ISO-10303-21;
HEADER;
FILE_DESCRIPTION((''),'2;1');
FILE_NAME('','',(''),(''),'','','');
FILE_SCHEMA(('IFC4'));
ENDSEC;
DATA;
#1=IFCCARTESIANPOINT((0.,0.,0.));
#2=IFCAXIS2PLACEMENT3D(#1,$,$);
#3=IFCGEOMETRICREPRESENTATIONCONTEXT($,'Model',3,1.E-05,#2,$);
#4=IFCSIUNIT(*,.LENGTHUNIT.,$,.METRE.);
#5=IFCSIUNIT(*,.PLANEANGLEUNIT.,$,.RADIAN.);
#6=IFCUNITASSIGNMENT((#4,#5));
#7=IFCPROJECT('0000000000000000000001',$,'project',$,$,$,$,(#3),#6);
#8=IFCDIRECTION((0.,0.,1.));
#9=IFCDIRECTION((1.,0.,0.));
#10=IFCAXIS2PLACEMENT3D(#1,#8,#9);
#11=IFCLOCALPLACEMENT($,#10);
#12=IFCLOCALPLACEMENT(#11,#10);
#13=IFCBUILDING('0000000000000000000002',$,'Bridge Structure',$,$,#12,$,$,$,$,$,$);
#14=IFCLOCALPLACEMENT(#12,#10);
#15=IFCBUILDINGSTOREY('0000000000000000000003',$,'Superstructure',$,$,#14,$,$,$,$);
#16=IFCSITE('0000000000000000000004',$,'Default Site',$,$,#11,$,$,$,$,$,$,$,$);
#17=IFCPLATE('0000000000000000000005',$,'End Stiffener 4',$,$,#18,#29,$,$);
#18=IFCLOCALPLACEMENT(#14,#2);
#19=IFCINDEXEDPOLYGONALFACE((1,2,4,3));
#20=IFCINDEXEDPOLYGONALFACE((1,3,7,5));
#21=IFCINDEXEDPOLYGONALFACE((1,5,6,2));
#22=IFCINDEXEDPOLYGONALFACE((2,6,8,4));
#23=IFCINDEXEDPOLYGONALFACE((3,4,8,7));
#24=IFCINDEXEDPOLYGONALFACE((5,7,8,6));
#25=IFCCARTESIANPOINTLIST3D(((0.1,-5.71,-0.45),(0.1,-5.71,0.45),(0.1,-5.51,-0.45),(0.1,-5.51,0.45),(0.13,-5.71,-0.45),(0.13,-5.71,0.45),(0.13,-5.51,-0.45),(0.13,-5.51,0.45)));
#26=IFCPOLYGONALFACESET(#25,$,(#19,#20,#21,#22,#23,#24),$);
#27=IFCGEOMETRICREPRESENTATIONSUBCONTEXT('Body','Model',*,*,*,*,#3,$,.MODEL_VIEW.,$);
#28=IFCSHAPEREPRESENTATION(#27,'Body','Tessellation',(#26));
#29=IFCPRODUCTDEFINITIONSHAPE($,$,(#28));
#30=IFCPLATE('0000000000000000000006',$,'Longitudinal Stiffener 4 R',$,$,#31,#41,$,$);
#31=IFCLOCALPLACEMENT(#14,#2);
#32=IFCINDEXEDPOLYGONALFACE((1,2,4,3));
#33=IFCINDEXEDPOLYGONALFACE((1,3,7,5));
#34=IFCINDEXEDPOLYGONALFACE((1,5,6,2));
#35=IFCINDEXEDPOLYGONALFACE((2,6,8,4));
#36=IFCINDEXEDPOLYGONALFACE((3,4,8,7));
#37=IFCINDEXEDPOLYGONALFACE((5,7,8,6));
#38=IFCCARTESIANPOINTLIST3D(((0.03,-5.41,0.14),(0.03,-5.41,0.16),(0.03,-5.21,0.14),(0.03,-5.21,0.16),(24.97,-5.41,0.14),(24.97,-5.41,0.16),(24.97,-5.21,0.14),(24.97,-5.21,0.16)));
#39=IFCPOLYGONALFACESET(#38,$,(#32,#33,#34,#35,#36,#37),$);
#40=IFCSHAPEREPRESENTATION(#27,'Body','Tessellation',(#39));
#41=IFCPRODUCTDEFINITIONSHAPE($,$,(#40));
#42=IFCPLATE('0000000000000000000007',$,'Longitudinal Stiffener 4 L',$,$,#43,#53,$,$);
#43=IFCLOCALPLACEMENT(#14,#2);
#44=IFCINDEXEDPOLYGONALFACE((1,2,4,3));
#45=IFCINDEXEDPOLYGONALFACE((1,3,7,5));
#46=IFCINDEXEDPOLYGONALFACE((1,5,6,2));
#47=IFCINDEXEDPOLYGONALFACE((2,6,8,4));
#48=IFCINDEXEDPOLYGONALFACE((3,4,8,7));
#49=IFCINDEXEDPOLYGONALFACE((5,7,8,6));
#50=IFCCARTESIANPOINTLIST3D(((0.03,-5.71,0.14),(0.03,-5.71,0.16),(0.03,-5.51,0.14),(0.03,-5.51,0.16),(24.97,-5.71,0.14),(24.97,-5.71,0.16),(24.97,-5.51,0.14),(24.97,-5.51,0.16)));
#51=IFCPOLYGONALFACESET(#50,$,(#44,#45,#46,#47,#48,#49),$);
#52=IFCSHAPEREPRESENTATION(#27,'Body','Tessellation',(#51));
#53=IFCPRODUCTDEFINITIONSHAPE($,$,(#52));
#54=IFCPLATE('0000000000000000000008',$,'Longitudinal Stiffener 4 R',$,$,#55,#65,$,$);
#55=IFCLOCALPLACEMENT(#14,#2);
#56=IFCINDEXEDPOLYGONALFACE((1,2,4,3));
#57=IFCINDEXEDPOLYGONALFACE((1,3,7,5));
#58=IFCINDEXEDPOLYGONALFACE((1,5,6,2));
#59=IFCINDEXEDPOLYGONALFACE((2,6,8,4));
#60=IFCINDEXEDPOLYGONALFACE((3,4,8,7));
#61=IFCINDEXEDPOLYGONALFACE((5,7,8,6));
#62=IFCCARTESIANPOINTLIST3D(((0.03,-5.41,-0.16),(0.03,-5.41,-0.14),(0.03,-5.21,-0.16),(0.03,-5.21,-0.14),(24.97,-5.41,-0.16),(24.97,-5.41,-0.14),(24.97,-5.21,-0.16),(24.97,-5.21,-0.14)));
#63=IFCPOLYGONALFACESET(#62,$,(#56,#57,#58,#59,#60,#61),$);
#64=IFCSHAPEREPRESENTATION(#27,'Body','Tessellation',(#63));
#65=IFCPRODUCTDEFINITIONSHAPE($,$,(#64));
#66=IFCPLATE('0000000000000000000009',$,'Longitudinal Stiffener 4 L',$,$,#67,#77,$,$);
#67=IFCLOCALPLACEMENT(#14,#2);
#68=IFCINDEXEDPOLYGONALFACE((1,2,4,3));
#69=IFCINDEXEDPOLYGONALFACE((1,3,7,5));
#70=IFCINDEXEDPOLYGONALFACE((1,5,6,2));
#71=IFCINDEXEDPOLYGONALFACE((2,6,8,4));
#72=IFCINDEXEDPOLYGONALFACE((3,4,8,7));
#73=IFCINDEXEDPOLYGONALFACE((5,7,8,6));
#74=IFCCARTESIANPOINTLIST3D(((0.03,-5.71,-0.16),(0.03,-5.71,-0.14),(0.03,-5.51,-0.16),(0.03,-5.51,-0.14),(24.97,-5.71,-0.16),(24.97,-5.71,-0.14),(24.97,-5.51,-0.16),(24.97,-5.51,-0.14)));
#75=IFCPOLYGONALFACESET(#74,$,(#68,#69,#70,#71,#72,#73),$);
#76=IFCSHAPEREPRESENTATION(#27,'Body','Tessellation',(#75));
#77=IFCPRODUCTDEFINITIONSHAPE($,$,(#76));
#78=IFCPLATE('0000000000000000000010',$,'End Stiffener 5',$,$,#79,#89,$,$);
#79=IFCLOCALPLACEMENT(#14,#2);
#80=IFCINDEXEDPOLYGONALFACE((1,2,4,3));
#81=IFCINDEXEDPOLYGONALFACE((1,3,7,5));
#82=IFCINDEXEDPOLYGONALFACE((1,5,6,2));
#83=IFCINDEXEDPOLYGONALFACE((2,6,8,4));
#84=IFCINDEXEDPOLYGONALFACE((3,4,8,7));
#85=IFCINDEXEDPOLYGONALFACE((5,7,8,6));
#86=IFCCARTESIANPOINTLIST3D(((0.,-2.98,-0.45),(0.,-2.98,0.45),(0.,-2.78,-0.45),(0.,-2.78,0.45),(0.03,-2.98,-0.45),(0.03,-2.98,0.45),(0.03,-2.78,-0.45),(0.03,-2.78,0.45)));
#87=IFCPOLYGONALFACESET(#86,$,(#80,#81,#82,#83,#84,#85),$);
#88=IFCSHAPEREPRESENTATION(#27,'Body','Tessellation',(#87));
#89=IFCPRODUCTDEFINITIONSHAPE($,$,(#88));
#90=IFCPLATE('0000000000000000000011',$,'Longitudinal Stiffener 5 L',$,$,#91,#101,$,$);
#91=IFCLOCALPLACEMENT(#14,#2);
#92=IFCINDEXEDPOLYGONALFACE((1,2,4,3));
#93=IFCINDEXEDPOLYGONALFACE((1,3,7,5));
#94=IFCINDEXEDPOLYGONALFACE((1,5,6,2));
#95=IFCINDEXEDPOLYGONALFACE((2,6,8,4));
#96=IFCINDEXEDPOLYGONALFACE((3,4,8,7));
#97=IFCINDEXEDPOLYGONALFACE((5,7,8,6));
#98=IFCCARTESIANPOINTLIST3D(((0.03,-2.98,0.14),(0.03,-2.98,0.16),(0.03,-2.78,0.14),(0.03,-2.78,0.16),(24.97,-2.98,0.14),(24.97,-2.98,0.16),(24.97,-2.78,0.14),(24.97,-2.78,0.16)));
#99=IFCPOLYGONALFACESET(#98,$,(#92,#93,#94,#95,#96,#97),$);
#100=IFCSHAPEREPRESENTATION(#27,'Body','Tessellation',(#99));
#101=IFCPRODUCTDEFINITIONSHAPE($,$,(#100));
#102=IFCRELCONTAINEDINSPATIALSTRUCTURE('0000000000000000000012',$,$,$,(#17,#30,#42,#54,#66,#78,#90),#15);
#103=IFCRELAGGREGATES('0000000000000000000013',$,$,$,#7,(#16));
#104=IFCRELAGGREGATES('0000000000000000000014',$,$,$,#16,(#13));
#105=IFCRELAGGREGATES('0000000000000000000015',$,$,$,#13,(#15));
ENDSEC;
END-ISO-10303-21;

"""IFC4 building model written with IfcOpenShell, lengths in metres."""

from ifc_helpers import new_model, si_unit, frame, origin, origin_with_axes, origin_2d_with_axis, place, context, subcontext, project, spatial, rectangle, extrude, element, save


model = new_model("IFC4")

# Units and contexts
model_context = context("Model", 3, precision=1e-05, world=origin())
body_context = subcontext(model_context, "Body", "Model", "MODEL_VIEW")
ifc_project = project(units=[si_unit("LENGTHUNIT", "METRE"), si_unit("PLANEANGLEUNIT", "RADIAN")], contexts=[model_context])

# Site, building, storey
site_placement = place(None, origin_with_axes())
site = spatial("IfcSite", under=ifc_project, at=site_placement, Name="Default Site")
building_placement = place(site_placement, origin_with_axes())
building = spatial("IfcBuilding", under=site, at=building_placement, Name="Bridge Structure")
storey_placement = place(building_placement, origin_with_axes())
storey = spatial("IfcBuildingStorey", under=building, at=storey_placement, Name="Superstructure")

# Plates
for number, where, z_axis, x_axis, name in (
    (1, (0.115, -5.61, -0.45), (0.0, 0.0, 1.0), (1.0, 0.0, 0.0), "End Stiffener 4"),
):
    element("IfcPlate", number, at=place(storey_placement, frame(where, z_axis=z_axis, x_axis=x_axis)), inside=storey, Name=name, context=body_context, shape_type="SweptSolid", body=[
        extrude(rectangle(XDim=0.03, YDim=0.2, at=origin_2d_with_axis()), origin_with_axes(), (0.0, 0.0, 1.0), 0.9),
    ])
for number, where, z_axis, x_axis, name in (
    (2, (0.03, -5.31, 0.15), (1.0, 0.0, 0.0), (0.0, 1.0, 0.0), "Longitudinal Stiffener 4 R"),
    (3, (0.03, -5.61, 0.15), (1.0, 0.0, 0.0), (0.0, 1.0, 0.0), "Longitudinal Stiffener 4 L"),
    (4, (0.03, -5.31, -0.15), (1.0, 0.0, 0.0), (0.0, 1.0, 0.0), "Longitudinal Stiffener 4 R"),
    (5, (0.03, -5.61, -0.15), (1.0, 0.0, 0.0), (0.0, 1.0, 0.0), "Longitudinal Stiffener 4 L"),
):
    element("IfcPlate", number, at=place(storey_placement, frame(where, z_axis=z_axis, x_axis=x_axis)), inside=storey, Name=name, context=body_context, shape_type="SweptSolid", body=[
        extrude(rectangle(XDim=0.2, YDim=0.02, at=origin_2d_with_axis()), origin_with_axes(), (0.0, 0.0, 1.0), 24.94),
    ])
plate_1_placement = place(storey_placement, frame((0.015, -2.88, -0.45), z_axis=(0.0, 0.0, 1.0), x_axis=(1.0, 0.0, 0.0)))
element("IfcPlate", 6, at=plate_1_placement, inside=storey, Name="End Stiffener 5", context=body_context, shape_type="SweptSolid", body=[
    extrude(rectangle(XDim=0.03, YDim=0.2, at=origin_2d_with_axis()), origin_with_axes(), (0.0, 0.0, 1.0), 0.9),
])
plate_2_placement = place(storey_placement, frame((0.03, -2.88, 0.15), z_axis=(1.0, 0.0, 0.0), x_axis=(0.0, 1.0, 0.0)))
element("IfcPlate", 7, at=plate_2_placement, inside=storey, Name="Longitudinal Stiffener 5 L", context=body_context, shape_type="SweptSolid", body=[
    extrude(rectangle(XDim=0.2, YDim=0.02, at=origin_2d_with_axis()), origin_with_axes(), (0.0, 0.0, 1.0), 24.94),
])

save(model, "model.ifc")
